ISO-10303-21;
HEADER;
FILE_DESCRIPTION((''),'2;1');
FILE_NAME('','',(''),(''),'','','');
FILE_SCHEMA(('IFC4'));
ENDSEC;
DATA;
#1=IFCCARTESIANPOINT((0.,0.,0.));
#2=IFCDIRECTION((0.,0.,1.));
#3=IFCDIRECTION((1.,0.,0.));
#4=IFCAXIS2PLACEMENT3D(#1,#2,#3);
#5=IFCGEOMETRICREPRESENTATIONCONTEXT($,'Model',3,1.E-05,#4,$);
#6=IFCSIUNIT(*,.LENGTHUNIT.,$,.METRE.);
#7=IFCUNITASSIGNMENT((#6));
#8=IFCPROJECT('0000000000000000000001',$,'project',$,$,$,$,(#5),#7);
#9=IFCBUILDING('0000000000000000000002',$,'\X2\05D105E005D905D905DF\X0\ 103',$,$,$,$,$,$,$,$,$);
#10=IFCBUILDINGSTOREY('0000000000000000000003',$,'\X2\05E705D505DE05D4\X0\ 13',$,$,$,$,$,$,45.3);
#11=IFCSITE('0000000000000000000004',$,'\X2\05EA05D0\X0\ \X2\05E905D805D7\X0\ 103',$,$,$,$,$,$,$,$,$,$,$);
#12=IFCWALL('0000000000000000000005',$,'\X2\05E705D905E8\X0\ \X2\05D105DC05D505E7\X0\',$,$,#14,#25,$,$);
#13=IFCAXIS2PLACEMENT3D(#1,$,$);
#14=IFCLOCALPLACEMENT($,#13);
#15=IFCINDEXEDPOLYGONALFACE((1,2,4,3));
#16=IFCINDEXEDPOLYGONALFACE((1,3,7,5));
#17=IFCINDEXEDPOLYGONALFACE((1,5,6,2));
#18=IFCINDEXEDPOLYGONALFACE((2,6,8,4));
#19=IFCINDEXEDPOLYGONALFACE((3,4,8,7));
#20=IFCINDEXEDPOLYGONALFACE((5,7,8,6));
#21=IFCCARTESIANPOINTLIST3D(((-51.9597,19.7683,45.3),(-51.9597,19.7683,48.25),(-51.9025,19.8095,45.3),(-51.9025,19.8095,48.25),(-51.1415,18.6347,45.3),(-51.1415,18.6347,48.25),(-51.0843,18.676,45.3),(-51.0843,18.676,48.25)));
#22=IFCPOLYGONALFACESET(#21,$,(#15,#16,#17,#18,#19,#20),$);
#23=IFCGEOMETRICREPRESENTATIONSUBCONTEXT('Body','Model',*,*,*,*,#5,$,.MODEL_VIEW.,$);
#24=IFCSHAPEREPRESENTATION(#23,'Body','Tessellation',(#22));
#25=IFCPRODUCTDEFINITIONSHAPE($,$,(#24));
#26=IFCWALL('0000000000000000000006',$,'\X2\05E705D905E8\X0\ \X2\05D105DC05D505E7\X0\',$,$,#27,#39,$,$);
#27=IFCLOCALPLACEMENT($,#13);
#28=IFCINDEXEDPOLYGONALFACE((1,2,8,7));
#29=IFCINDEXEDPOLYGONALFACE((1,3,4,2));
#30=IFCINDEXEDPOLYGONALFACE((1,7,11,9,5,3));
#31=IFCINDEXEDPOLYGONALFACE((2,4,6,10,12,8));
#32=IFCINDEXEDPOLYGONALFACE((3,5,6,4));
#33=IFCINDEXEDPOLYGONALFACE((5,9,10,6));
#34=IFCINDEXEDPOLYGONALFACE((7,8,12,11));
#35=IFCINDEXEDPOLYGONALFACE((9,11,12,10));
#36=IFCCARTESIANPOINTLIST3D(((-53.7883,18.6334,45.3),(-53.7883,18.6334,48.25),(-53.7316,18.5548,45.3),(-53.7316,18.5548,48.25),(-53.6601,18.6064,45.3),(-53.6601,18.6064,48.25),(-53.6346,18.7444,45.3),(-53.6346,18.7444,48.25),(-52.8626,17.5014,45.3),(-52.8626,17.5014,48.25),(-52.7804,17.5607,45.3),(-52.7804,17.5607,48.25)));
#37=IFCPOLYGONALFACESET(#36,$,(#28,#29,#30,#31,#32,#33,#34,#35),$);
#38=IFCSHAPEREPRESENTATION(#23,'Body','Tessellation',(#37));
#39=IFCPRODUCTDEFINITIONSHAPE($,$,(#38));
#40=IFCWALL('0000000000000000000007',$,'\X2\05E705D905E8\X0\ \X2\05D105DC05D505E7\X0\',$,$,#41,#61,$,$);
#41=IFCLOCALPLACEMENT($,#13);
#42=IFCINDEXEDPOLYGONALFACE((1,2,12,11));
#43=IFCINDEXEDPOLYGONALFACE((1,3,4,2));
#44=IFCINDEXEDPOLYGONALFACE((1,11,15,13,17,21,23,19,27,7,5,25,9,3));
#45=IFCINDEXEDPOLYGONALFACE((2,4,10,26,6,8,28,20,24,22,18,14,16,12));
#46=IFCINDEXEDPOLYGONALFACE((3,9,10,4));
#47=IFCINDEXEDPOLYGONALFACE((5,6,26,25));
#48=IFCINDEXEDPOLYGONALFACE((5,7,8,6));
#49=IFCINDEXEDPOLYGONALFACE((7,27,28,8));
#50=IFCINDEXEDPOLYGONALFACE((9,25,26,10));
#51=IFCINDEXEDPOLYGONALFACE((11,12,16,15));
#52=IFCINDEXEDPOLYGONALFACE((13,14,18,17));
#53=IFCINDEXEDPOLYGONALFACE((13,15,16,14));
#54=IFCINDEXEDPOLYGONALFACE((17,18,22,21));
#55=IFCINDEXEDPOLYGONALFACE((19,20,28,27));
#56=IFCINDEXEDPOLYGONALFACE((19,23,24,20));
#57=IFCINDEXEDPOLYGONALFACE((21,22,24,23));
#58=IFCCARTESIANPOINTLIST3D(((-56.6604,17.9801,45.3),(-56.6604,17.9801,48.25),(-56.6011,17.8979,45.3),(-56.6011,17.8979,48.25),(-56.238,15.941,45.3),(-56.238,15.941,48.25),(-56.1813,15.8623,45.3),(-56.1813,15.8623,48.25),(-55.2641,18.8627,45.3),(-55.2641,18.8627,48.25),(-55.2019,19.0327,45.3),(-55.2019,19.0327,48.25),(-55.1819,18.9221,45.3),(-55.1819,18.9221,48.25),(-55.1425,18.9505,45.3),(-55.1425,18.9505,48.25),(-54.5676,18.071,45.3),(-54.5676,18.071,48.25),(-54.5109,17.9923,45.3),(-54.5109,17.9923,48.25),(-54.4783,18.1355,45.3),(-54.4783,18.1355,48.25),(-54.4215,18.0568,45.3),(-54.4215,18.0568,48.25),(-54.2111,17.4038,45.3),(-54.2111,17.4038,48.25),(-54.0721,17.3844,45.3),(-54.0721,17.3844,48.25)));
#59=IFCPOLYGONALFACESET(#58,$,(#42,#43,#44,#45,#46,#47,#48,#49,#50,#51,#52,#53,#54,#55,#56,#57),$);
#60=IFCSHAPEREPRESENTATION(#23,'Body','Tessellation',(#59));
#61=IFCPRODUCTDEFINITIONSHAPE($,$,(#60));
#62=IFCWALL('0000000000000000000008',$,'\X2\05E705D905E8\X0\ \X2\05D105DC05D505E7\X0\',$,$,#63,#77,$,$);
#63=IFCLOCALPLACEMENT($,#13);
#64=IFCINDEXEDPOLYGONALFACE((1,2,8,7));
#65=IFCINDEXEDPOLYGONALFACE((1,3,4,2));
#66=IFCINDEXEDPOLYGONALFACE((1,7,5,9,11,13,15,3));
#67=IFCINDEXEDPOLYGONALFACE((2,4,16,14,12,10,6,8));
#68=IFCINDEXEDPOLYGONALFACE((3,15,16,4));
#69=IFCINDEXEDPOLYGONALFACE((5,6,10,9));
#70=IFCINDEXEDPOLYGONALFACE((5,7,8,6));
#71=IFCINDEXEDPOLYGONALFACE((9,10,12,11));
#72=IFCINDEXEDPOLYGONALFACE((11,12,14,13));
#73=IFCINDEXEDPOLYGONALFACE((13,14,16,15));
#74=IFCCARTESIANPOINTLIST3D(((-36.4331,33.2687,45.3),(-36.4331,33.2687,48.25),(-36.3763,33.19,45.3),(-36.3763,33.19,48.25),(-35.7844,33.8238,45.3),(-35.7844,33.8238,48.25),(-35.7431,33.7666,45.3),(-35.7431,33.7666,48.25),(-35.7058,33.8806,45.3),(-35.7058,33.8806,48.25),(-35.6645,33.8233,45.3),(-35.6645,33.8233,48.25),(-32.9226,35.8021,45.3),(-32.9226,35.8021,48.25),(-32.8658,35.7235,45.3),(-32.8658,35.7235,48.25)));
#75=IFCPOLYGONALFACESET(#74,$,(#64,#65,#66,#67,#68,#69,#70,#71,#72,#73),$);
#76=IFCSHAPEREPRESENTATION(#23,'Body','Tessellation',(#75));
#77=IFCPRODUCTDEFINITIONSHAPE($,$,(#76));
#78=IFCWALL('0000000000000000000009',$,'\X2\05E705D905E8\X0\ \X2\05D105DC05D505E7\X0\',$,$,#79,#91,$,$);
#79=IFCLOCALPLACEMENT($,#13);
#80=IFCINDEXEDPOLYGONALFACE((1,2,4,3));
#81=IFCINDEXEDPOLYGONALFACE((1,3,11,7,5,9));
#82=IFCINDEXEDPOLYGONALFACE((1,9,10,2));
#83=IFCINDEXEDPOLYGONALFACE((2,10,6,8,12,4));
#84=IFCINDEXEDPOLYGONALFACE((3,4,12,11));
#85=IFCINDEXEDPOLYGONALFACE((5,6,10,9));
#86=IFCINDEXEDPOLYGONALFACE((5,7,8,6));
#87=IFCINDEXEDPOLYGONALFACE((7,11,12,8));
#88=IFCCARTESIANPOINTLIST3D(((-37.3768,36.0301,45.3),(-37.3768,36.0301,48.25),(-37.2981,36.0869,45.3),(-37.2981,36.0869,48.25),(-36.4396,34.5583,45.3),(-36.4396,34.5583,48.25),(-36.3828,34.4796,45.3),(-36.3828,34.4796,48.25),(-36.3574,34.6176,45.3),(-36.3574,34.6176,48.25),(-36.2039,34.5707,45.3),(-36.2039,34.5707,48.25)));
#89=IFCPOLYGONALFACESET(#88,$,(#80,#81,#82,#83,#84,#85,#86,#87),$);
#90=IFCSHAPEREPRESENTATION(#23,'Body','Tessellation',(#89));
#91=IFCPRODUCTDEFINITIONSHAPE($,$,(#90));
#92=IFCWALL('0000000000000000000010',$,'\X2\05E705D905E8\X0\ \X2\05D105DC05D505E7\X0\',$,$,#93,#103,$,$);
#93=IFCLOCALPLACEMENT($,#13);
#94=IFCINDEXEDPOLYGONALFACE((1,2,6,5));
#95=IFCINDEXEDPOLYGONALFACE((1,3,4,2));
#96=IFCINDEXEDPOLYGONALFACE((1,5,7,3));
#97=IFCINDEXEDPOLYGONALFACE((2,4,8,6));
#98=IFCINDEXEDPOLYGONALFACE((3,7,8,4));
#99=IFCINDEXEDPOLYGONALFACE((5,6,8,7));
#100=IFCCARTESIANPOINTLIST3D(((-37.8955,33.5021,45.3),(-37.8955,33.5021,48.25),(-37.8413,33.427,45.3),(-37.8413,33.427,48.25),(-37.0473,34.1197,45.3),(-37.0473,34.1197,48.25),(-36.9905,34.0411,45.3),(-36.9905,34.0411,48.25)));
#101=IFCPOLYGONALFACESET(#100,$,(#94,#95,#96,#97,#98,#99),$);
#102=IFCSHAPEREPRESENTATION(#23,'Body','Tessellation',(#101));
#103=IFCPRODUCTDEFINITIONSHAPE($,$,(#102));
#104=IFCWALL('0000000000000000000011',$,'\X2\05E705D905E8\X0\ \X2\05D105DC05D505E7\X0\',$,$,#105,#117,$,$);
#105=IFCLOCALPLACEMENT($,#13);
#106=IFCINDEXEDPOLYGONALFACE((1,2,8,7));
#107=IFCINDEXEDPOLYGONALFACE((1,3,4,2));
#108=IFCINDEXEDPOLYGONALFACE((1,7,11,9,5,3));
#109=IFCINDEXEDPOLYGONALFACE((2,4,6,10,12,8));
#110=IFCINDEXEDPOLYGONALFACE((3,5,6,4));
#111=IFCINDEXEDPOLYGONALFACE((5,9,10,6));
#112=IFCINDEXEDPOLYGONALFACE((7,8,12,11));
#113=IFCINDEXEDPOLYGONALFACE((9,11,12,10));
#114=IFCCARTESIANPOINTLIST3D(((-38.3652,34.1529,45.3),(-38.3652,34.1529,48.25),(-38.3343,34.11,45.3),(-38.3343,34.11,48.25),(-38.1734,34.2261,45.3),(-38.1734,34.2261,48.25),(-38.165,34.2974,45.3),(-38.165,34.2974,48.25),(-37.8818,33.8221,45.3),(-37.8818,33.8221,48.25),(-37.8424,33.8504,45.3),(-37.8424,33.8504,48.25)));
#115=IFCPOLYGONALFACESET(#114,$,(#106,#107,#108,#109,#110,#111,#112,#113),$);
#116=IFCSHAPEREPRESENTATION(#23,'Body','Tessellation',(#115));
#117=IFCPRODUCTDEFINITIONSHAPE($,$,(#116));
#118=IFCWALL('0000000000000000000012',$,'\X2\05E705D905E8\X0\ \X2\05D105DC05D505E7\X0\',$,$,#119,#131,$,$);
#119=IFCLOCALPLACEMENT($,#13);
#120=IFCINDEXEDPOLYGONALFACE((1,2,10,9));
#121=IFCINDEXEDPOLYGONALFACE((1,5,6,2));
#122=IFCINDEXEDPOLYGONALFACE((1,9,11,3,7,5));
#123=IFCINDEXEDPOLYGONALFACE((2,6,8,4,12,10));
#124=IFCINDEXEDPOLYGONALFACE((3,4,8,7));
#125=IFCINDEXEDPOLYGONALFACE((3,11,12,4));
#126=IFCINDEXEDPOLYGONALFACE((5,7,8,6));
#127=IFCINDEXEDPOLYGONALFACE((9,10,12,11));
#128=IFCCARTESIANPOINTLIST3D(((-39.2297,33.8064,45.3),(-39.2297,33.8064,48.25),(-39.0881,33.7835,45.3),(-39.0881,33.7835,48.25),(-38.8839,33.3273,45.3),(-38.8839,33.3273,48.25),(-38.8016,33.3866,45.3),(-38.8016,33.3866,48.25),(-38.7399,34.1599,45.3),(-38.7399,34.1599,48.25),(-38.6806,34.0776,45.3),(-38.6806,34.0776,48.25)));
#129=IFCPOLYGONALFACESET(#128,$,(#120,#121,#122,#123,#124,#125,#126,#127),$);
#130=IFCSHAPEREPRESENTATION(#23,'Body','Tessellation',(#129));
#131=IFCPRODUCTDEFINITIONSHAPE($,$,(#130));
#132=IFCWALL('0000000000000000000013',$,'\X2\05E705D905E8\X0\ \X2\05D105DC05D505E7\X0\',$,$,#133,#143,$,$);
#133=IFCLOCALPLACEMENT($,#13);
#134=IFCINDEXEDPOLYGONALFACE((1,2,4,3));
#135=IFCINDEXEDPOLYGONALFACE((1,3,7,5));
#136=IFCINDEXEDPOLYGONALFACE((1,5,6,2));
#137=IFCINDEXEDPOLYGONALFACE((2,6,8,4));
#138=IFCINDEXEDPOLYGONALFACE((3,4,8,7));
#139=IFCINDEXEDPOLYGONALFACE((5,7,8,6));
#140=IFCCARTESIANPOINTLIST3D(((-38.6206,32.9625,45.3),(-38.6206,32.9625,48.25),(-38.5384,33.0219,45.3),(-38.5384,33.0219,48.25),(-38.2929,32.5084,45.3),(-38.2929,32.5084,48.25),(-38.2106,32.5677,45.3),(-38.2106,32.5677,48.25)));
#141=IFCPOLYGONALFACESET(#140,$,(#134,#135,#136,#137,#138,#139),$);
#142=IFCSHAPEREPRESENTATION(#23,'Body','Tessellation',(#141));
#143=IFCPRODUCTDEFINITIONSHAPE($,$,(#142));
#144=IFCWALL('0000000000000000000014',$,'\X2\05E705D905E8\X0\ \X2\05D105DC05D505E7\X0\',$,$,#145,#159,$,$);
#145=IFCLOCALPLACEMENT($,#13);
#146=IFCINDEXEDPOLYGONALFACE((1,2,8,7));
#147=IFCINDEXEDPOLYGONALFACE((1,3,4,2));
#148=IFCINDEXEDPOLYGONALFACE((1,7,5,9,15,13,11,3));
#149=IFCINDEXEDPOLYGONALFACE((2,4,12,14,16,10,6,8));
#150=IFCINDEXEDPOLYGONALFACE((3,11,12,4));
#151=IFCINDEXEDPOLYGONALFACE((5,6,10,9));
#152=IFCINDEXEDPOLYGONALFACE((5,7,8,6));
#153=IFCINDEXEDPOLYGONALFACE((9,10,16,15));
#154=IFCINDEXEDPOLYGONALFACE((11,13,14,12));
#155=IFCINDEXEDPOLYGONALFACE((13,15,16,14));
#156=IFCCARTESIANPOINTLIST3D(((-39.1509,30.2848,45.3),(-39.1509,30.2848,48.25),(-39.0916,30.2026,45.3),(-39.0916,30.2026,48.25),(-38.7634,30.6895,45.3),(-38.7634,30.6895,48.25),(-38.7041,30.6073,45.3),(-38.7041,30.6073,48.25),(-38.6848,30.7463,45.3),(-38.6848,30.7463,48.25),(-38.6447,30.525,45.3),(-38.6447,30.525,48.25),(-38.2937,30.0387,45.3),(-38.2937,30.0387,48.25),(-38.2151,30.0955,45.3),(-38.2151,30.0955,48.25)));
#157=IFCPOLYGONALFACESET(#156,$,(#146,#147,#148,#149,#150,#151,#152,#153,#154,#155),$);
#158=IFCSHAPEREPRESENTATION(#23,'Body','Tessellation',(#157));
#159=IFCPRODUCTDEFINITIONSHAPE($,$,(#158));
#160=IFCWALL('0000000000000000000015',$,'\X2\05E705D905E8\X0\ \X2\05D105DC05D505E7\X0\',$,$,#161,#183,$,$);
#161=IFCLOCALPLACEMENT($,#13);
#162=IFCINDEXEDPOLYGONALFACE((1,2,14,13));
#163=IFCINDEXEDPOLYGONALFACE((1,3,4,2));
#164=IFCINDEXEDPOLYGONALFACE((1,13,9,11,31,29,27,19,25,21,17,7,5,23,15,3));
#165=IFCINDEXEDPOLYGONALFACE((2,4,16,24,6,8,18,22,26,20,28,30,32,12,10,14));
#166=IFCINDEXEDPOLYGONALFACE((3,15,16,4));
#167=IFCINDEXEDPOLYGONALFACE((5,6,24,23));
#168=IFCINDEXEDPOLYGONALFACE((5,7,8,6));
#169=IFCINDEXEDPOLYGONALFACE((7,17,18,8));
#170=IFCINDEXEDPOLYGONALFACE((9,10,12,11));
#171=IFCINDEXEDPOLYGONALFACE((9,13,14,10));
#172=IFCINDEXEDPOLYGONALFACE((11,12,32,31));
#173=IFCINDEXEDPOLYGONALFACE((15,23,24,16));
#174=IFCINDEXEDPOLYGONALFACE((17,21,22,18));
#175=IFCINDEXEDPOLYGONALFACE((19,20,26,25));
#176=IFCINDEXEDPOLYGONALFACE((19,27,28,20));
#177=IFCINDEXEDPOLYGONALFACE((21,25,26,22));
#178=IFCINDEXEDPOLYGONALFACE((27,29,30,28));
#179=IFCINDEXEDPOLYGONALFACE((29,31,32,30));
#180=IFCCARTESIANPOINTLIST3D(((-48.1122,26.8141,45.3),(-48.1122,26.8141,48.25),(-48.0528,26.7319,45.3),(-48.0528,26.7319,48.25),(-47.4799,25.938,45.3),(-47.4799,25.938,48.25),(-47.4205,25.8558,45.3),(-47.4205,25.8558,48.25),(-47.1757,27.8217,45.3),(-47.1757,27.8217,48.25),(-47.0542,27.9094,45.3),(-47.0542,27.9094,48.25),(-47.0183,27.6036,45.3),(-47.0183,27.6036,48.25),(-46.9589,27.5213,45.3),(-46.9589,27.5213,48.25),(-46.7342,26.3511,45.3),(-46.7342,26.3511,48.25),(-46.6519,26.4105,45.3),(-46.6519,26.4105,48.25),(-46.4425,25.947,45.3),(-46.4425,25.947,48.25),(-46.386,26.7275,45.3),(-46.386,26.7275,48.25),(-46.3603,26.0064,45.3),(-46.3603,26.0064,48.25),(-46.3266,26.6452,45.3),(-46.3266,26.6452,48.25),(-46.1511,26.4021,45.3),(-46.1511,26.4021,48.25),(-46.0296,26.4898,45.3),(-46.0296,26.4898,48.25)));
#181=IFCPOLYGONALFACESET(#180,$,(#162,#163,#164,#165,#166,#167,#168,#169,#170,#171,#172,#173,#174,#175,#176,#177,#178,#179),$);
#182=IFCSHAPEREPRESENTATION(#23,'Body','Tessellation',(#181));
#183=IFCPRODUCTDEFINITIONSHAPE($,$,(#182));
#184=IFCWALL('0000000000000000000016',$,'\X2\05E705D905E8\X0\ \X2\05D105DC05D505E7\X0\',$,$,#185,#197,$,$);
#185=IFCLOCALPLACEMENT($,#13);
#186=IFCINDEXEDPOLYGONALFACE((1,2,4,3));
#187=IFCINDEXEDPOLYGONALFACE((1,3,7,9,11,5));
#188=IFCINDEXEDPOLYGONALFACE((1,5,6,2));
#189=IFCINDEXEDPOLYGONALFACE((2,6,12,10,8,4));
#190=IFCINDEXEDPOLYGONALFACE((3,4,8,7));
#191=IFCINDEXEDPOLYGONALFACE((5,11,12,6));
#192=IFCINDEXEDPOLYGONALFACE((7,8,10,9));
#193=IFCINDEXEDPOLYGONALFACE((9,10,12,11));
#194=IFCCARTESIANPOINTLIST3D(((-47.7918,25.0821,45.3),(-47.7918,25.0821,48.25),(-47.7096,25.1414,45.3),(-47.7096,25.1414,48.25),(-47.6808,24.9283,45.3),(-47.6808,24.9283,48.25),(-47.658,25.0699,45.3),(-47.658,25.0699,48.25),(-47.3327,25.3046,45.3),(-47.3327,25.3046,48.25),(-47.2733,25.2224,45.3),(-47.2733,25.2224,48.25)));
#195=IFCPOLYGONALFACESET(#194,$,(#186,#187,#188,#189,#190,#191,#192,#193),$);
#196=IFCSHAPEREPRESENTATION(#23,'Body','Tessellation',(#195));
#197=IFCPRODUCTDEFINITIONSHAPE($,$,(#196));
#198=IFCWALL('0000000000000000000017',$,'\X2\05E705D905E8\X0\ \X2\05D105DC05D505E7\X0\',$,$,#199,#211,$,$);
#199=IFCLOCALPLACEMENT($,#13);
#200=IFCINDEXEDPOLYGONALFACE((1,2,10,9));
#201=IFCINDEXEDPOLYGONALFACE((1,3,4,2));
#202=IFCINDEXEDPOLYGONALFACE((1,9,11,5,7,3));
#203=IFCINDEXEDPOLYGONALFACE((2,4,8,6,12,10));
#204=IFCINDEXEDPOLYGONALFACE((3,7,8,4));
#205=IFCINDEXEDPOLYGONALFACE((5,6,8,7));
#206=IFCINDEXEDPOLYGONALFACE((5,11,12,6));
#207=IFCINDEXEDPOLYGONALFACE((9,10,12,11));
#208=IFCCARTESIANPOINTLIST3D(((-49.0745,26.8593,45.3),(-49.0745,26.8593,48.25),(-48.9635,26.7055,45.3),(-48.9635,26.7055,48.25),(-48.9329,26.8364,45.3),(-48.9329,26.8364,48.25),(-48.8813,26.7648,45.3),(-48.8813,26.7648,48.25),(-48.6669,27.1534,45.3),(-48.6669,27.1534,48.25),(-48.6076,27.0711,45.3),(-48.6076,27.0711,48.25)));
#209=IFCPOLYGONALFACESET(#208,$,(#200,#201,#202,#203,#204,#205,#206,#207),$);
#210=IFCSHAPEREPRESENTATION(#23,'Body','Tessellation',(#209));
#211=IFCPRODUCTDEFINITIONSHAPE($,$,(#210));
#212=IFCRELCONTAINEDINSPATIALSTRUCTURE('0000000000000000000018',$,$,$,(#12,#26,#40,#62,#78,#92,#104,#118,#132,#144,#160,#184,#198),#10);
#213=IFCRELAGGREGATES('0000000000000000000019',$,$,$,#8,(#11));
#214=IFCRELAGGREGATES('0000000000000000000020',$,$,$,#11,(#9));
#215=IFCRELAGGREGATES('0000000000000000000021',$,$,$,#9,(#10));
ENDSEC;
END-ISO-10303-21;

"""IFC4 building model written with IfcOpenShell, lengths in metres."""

from ifc_helpers import new_model, si_unit, frame, origin_with_axes, context, subcontext, project, spatial, polyline, outline, extrude, element, save


model = new_model("IFC4")

# Units and contexts
model_context = context("Model", 3, precision=1e-05, world=origin_with_axes())
body_context = subcontext(model_context, "Body", "Model", "MODEL_VIEW")
ifc_project = project(units=[si_unit("LENGTHUNIT", "METRE")], contexts=[model_context])

# Site, building, storey
site = spatial("IfcSite", under=ifc_project, Name="תא שטח 103")
building = spatial("IfcBuilding", under=site, Name="בניין 103")
storey = spatial("IfcBuildingStorey", under=building, Name="קומה 13", Elevation=45.3)

# Walls
element("IfcWall", 1, inside=storey, Name="קיר בלוק", context=body_context, shape_type="SweptSolid", body=[
    extrude(outline(polyline([(-51.9025, 19.8095), (-51.0843, 18.676), (-51.1415, 18.6347), (-51.9597, 19.7683), (-51.9025, 19.8095)])), frame((0.0, 0.0, 45.3)), (0.0, 0.0, 1.0), 2.95),
])
element("IfcWall", 2, inside=storey, Name="קיר בלוק", context=body_context, shape_type="SweptSolid", body=[
    extrude(outline(polyline([(-52.8626, 17.5014), (-53.6601, 18.6064), (-53.7316, 18.5548), (-53.7883, 18.6334), (-53.6346, 18.7444), (-52.7804, 17.5607), (-52.8626, 17.5014)])), frame((0.0, 0.0, 45.3)), (0.0, 0.0, 1.0), 2.95),
])
element("IfcWall", 3, inside=storey, Name="קיר בלוק", context=body_context, shape_type="SweptSolid", body=[
    extrude(outline(polyline([(-54.2111, 17.4038), (-55.2641, 18.8627), (-56.6011, 17.8979), (-56.6604, 17.9801), (-55.2019, 19.0327), (-55.1425, 18.9505), (-55.1819, 18.9221), (-54.5676, 18.071), (-54.4783, 18.1355), (-54.4215, 18.0568), (-54.5109, 17.9923), (-54.0721, 17.3844), (-56.1813, 15.8623), (-56.238, 15.941), (-54.2111, 17.4038)])), frame((0.0, 0.0, 45.3)), (0.0, 0.0, 1.0), 2.95),
])
element("IfcWall", 4, inside=storey, Name="קיר בלוק", context=body_context, shape_type="SweptSolid", body=[
    extrude(outline(polyline([(-32.8658, 35.7235), (-36.3763, 33.19), (-36.4331, 33.2687), (-35.7431, 33.7666), (-35.7844, 33.8238), (-35.7058, 33.8806), (-35.6645, 33.8233), (-32.9226, 35.8021), (-32.8658, 35.7235)])), frame((0.0, 0.0, 45.3)), (0.0, 0.0, 1.0), 2.95),
])
element("IfcWall", 5, inside=storey, Name="קיר בלוק", context=body_context, shape_type="SweptSolid", body=[
    extrude(outline(polyline([(-36.3828, 34.4796), (-36.4396, 34.5583), (-36.3574, 34.6176), (-37.3768, 36.0301), (-37.2981, 36.0869), (-36.2039, 34.5707), (-36.3828, 34.4796)])), frame((0.0, 0.0, 45.3)), (0.0, 0.0, 1.0), 2.95),
])
element("IfcWall", 6, inside=storey, Name="קיר בלוק", context=body_context, shape_type="SweptSolid", body=[
    extrude(outline(polyline([(-37.8413, 33.427), (-37.8955, 33.5021), (-37.0473, 34.1197), (-36.9905, 34.0411), (-37.8413, 33.427)])), frame((0.0, 0.0, 45.3)), (0.0, 0.0, 1.0), 2.95),
])
element("IfcWall", 7, inside=storey, Name="קיר בלוק", context=body_context, shape_type="SweptSolid", body=[
    extrude(outline(polyline([(-37.8818, 33.8221), (-38.1734, 34.2261), (-38.3343, 34.11), (-38.3652, 34.1529), (-38.165, 34.2974), (-37.8424, 33.8504), (-37.8818, 33.8221)])), frame((0.0, 0.0, 45.3)), (0.0, 0.0, 1.0), 2.95),
])
element("IfcWall", 8, inside=storey, Name="קיר בלוק", context=body_context, shape_type="SweptSolid", body=[
    extrude(outline(polyline([(-38.8016, 33.3866), (-38.8839, 33.3273), (-39.2297, 33.8064), (-38.7399, 34.1599), (-38.6806, 34.0776), (-39.0881, 33.7835), (-38.8016, 33.3866)])), frame((0.0, 0.0, 45.3)), (0.0, 0.0, 1.0), 2.95),
])
element("IfcWall", 9, inside=storey, Name="קיר בלוק", context=body_context, shape_type="SweptSolid", body=[
    extrude(outline(polyline([(-38.2106, 32.5677), (-38.2929, 32.5084), (-38.6206, 32.9625), (-38.5384, 33.0219), (-38.2106, 32.5677)])), frame((0.0, 0.0, 45.3)), (0.0, 0.0, 1.0), 2.95),
])
element("IfcWall", 10, inside=storey, Name="קיר בלוק", context=body_context, shape_type="SweptSolid", body=[
    extrude(outline(polyline([(-38.7041, 30.6073), (-38.7634, 30.6895), (-38.6848, 30.7463), (-38.2151, 30.0955), (-38.2937, 30.0387), (-38.6447, 30.525), (-39.0916, 30.2026), (-39.1509, 30.2848), (-38.7041, 30.6073)])), frame((0.0, 0.0, 45.3)), (0.0, 0.0, 1.0), 2.95),
])
element("IfcWall", 11, inside=storey, Name="קיר בלוק", context=body_context, shape_type="SweptSolid", body=[
    extrude(outline(polyline([(-46.3603, 26.0064), (-46.4425, 25.947), (-46.7342, 26.3511), (-47.4205, 25.8558), (-47.4799, 25.938), (-46.386, 26.7275), (-46.9589, 27.5213), (-48.0528, 26.7319), (-48.1122, 26.8141), (-47.0183, 27.6036), (-47.1757, 27.8217), (-47.0542, 27.9094), (-46.0296, 26.4898), (-46.1511, 26.4021), (-46.3266, 26.6452), (-46.6519, 26.4105), (-46.3603, 26.0064)])), frame((0.0, 0.0, 45.3)), (0.0, 0.0, 1.0), 2.95),
])
element("IfcWall", 12, inside=storey, Name="קיר בלוק", context=body_context, shape_type="SweptSolid", body=[
    extrude(outline(polyline([(-47.7096, 25.1414), (-47.658, 25.0699), (-47.3327, 25.3046), (-47.2733, 25.2224), (-47.6808, 24.9283), (-47.7918, 25.0821), (-47.7096, 25.1414)])), frame((0.0, 0.0, 45.3)), (0.0, 0.0, 1.0), 2.95),
])
element("IfcWall", 13, inside=storey, Name="קיר בלוק", context=body_context, shape_type="SweptSolid", body=[
    extrude(outline(polyline([(-49.0745, 26.8593), (-48.6669, 27.1534), (-48.6076, 27.0711), (-48.9329, 26.8364), (-48.8813, 26.7648), (-48.9635, 26.7055), (-49.0745, 26.8593)])), frame((0.0, 0.0, 45.3)), (0.0, 0.0, 1.0), 2.95),
])

save(model, "model.ifc")
